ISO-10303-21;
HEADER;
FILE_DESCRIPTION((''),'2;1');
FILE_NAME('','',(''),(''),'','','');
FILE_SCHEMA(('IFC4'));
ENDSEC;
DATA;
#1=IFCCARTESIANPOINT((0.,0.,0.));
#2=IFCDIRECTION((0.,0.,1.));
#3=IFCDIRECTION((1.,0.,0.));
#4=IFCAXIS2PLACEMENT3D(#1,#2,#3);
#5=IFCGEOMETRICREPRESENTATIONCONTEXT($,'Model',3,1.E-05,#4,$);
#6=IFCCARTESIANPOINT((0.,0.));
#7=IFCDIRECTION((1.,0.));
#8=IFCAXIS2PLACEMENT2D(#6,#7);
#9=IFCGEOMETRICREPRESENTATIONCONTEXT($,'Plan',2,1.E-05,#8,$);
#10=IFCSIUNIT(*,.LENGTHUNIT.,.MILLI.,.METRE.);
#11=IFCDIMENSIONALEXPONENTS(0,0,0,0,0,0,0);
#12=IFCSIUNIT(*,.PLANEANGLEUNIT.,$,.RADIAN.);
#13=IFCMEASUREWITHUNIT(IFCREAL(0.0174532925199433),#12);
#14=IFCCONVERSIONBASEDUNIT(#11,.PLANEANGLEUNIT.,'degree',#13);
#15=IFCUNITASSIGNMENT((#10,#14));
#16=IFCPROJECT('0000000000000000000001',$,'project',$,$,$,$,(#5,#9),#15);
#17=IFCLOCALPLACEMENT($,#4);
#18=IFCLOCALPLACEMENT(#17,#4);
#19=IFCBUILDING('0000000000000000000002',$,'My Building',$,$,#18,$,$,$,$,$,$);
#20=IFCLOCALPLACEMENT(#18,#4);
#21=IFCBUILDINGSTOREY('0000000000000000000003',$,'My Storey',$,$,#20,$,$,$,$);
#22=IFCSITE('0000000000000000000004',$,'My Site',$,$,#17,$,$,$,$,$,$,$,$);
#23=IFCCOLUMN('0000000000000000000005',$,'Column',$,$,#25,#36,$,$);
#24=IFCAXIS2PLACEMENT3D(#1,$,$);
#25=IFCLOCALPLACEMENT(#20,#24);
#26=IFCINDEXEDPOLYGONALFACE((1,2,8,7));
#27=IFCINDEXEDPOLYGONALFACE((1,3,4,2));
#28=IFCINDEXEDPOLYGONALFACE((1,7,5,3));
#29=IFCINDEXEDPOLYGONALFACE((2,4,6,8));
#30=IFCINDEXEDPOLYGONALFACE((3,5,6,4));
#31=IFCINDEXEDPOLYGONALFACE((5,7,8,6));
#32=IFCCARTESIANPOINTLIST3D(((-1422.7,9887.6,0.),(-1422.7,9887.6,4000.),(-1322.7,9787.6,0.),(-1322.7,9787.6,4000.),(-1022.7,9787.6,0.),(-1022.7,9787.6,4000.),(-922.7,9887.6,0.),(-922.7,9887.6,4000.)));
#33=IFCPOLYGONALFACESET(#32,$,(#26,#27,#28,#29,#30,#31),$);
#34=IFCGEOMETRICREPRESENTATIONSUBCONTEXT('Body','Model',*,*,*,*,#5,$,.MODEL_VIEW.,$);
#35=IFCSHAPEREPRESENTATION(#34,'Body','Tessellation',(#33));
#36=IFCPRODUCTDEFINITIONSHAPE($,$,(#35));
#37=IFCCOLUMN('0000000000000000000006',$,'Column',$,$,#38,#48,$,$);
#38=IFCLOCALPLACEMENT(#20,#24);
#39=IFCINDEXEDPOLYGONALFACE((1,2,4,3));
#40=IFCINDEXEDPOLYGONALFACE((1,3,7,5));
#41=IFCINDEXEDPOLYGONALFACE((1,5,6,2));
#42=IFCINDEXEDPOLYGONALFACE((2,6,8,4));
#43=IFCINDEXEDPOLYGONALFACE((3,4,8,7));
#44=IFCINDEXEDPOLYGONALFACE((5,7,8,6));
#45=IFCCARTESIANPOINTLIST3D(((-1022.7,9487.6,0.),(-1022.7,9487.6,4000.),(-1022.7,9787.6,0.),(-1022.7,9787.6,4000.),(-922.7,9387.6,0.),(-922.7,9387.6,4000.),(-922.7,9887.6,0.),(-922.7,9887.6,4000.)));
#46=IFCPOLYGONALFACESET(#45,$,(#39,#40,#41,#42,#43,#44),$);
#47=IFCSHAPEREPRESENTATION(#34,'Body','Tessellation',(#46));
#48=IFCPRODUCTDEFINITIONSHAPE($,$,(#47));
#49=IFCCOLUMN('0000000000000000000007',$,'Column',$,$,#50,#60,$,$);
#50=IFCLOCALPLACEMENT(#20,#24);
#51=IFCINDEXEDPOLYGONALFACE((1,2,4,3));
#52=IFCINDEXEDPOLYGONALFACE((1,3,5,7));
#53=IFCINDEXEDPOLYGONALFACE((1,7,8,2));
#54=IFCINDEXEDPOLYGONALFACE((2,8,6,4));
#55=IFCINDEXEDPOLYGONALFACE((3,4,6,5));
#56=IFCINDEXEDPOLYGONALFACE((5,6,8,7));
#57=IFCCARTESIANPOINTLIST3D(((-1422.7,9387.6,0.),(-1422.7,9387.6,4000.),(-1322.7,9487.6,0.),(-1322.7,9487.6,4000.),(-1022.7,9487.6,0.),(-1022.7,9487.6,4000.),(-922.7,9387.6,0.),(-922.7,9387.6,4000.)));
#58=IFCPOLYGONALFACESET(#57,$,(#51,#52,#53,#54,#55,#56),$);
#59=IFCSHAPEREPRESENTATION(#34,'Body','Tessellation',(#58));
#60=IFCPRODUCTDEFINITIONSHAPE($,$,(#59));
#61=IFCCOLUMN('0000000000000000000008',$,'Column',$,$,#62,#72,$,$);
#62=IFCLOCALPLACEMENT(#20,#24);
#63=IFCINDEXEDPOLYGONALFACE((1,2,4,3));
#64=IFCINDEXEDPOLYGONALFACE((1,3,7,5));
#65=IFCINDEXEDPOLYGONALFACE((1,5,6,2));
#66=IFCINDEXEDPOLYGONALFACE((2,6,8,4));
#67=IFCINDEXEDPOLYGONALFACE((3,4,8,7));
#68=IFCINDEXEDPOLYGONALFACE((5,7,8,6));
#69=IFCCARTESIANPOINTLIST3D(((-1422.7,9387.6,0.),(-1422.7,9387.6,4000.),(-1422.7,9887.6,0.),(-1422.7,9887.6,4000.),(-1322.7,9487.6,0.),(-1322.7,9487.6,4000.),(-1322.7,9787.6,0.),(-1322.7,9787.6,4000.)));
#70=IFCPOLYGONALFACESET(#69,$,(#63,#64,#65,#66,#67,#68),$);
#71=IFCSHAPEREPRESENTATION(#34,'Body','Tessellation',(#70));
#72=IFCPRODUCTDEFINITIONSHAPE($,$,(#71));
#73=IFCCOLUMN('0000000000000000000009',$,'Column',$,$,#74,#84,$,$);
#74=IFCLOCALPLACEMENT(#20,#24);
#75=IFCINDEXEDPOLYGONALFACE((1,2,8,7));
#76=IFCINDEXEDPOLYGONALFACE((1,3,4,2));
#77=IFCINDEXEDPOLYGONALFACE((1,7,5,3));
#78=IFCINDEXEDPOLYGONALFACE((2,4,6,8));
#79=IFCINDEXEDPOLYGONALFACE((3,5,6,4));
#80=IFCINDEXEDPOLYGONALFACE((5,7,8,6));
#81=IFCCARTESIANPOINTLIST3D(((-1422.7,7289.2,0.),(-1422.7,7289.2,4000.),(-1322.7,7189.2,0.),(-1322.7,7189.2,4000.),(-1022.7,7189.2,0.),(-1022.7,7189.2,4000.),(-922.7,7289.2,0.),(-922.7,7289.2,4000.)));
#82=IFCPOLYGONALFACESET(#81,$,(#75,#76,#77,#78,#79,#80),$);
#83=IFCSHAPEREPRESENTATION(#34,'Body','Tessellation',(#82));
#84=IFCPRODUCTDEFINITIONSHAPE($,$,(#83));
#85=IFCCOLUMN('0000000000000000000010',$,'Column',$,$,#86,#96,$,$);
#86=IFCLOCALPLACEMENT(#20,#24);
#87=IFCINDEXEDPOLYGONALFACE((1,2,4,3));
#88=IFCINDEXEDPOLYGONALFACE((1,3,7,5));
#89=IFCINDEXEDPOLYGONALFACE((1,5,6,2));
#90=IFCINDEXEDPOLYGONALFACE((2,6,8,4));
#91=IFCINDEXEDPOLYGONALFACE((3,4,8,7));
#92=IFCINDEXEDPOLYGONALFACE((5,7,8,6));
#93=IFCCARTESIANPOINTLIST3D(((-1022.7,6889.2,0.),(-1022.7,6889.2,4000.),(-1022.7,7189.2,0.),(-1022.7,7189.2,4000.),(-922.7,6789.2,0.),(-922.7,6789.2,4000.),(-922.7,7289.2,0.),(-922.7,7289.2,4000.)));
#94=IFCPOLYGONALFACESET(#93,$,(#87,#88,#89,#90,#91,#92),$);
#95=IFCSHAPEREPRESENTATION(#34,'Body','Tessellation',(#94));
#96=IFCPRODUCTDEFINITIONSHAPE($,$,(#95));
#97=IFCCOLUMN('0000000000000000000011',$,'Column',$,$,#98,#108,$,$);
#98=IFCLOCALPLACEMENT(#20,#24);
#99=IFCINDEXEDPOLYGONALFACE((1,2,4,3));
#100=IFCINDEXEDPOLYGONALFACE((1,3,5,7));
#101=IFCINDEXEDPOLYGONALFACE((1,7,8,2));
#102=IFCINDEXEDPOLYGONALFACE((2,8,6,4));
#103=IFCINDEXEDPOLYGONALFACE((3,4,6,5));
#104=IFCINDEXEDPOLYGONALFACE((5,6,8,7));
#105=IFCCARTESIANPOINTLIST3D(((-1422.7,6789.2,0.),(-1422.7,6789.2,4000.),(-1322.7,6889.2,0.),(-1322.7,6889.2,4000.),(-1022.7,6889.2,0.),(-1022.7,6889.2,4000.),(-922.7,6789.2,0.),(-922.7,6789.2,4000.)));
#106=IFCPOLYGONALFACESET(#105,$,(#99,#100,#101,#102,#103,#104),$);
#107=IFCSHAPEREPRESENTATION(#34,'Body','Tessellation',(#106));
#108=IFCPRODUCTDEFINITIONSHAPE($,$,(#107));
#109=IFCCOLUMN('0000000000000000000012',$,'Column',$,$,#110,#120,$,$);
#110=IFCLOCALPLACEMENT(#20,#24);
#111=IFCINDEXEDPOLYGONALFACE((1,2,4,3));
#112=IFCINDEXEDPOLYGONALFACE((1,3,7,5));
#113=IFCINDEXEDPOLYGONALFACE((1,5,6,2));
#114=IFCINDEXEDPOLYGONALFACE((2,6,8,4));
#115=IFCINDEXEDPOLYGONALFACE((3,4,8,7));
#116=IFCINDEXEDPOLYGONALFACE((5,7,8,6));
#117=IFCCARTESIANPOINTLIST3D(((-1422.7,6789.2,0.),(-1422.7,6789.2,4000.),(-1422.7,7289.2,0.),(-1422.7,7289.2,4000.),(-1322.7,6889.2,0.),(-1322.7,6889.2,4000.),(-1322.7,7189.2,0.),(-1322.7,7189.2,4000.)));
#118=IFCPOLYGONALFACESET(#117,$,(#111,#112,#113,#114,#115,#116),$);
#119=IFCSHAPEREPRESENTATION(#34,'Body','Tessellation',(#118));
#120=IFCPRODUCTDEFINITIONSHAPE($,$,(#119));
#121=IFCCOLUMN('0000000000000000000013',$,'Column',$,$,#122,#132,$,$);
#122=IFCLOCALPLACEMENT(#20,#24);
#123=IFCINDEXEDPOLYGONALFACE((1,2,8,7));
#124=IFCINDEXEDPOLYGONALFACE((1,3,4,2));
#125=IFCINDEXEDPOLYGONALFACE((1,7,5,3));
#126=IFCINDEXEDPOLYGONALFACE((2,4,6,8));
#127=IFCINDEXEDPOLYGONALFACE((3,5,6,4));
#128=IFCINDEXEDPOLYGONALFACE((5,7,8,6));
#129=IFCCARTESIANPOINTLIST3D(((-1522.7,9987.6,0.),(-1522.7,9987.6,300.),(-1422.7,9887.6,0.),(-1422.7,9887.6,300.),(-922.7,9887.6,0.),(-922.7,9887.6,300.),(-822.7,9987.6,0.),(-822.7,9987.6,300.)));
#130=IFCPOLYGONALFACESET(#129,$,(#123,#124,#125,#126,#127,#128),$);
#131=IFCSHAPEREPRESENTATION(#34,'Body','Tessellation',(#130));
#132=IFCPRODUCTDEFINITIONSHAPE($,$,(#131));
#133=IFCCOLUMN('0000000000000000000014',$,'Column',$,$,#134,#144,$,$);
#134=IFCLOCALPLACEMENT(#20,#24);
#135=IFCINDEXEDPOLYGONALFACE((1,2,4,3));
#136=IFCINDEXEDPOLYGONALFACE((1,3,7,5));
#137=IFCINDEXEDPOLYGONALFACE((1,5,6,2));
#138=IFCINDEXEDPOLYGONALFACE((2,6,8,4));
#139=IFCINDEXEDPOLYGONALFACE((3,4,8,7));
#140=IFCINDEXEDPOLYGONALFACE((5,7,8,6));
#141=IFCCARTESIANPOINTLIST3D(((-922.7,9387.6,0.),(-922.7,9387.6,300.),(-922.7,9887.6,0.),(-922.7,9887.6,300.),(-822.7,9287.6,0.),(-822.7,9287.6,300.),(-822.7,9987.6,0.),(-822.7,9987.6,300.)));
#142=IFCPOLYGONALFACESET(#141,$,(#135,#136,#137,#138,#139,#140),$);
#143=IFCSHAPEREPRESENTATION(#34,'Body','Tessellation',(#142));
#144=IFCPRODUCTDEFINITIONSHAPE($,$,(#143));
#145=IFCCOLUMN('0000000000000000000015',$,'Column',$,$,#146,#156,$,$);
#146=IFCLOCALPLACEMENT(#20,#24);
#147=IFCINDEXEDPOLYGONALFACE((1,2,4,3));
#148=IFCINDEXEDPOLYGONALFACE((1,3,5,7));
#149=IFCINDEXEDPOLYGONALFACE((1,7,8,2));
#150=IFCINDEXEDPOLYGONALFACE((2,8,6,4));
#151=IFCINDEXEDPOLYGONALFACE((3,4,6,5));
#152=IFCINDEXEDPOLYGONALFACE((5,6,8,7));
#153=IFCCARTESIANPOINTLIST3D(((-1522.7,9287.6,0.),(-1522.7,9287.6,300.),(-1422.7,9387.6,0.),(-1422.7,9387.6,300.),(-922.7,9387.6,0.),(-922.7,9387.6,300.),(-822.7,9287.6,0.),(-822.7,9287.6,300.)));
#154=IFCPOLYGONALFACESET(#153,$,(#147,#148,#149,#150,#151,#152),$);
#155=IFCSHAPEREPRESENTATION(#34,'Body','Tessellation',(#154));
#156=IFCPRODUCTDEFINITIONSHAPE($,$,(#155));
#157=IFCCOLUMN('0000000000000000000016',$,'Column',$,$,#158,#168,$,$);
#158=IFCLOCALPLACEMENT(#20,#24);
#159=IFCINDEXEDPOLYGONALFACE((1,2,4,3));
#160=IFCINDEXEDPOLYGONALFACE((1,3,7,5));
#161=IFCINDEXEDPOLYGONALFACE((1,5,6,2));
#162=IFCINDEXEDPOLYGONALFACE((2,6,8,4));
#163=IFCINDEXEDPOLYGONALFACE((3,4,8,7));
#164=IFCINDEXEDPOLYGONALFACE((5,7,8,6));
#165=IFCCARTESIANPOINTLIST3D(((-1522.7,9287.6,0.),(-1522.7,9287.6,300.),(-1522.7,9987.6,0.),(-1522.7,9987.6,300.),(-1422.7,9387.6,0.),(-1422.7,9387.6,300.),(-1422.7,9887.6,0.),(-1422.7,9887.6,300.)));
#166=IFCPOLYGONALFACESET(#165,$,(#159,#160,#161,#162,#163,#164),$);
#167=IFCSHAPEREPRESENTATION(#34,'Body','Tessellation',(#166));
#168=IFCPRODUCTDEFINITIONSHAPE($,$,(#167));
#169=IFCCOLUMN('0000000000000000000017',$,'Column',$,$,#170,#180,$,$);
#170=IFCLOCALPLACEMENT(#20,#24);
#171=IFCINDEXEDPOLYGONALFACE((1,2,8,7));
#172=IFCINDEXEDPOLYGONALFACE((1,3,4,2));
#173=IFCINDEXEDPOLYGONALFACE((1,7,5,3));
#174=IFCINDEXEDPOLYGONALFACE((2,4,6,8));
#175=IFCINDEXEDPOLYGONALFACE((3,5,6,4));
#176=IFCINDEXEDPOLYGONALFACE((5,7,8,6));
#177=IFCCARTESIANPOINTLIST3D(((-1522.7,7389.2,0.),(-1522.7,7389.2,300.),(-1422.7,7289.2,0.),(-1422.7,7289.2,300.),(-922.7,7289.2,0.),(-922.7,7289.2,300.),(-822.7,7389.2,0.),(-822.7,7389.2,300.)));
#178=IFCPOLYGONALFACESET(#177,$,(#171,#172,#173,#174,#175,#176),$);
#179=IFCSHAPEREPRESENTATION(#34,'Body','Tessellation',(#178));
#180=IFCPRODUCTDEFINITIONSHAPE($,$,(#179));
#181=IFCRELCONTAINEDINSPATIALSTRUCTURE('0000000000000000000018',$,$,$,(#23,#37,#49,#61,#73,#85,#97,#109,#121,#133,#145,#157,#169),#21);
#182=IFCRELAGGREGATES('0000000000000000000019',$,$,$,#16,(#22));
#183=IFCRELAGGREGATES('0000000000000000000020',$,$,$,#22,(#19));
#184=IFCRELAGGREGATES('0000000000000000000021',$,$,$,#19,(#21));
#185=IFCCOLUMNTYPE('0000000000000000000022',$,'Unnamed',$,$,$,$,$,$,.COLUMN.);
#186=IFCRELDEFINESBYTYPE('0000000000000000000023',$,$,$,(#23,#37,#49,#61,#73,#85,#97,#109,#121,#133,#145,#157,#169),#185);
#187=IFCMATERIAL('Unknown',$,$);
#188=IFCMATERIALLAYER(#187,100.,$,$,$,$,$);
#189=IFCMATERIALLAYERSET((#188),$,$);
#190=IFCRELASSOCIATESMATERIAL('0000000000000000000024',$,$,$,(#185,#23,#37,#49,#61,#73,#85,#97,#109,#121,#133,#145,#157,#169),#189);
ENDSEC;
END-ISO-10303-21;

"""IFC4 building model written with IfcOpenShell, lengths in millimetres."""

from ifc_helpers import new_model, entity, si_unit, converted_unit, frame, origin_with_axes, origin_2d_with_axis, place, context, subcontext, project, spatial, line, indexed_curve, outline, extrude, material, layer, layer_set, layer_usage, type_object, element, save


model = new_model("IFC4")

# Units and contexts
model_context = context("Model", 3, precision=1e-05, world=origin_with_axes())
plan_context = context("Plan", 2, precision=1e-05, world=origin_2d_with_axis())
body_context = subcontext(model_context, "Body", "Model", "MODEL_VIEW")
ifc_project = project(units=[si_unit("LENGTHUNIT", "METRE", prefix="MILLI"), converted_unit("PLANEANGLEUNIT", "degree", entity("IfcReal", 0.0174532925199433), si_unit("PLANEANGLEUNIT", "RADIAN"), dimensions=[0, 0, 0, 0, 0, 0, 0])], contexts=[model_context, plan_context])

# Site, building, storey
site_placement = place(None, origin_with_axes())
site = spatial("IfcSite", under=ifc_project, at=site_placement, Name="My Site")
building_placement = place(site_placement, origin_with_axes())
building = spatial("IfcBuilding", under=site, at=building_placement, Name="My Building")
storey_placement = place(building_placement, origin_with_axes())
storey = spatial("IfcBuildingStorey", under=building, at=storey_placement, Name="My Storey")

# Columns
ifc_material = material(Name="Unknown")
ifc_layer_1 = layer(ifc_material, 100.0)
ifc_layer_set_1 = layer_set([ifc_layer_1])
ifc_layer_usage_1 = layer_usage(ifc_layer_set_1, "AXIS2", "POSITIVE", 0.0)
column_type = type_object("IfcColumnType", Name="Unnamed", PredefinedType="COLUMN", material=ifc_layer_set_1)
column_1_placement = place(storey_placement, frame((-1322.7, 9787.6, 0.0), z_axis=(0.0, 0.0, 1.0), x_axis=(1.0, 0.0, 0.0)))
element("IfcColumn", 1, at=column_1_placement, inside=storey, type_object=column_type, material=ifc_layer_usage_1, Name="Column", context=body_context, shape_type="SweptSolid", body=[
    extrude(outline(indexed_curve([(0.0, 0.0), (-100.0, 100.0), (400.0, 100.0), (300.0, 0.0)], segments=[line(1, 2, 3, 4, 1)])), origin_with_axes(), (0.0, 0.0, 1.0), 4000.0),
])
ifc_layer_usage_2 = layer_usage(ifc_layer_set_1, "AXIS2", "POSITIVE", 0.0)
column_2_placement = place(storey_placement, frame((-1022.7, 9787.6, 0.0), z_axis=(0.0, 0.0, 1.0), x_axis=(0.0, -1.0, 0.0)))
element("IfcColumn", 2, at=column_2_placement, inside=storey, type_object=column_type, material=ifc_layer_usage_2, Name="Column", context=body_context, shape_type="SweptSolid", body=[
    extrude(outline(indexed_curve([(0.0, 0.0), (-100.0, 100.0), (400.0, 100.0), (300.0, 0.0)], segments=[line(1, 2, 3, 4, 1)])), origin_with_axes(), (0.0, 0.0, 1.0), 4000.0),
])
ifc_layer_usage_3 = layer_usage(ifc_layer_set_1, "AXIS2", "POSITIVE", 0.0)
column_3_placement = place(storey_placement, frame((-1022.7, 9487.6, 0.0), z_axis=(0.0, 0.0, 1.0), x_axis=(-1.0, 0.0, 0.0)))
element("IfcColumn", 3, at=column_3_placement, inside=storey, type_object=column_type, material=ifc_layer_usage_3, Name="Column", context=body_context, shape_type="SweptSolid", body=[
    extrude(outline(indexed_curve([(0.0, 0.0), (-100.0, 100.0), (400.0, 100.0), (300.0, 0.0)], segments=[line(1, 2, 3, 4, 1)])), origin_with_axes(), (0.0, 0.0, 1.0), 4000.0),
])
ifc_layer_usage_4 = layer_usage(ifc_layer_set_1, "AXIS2", "POSITIVE", 0.0)
column_4_placement = place(storey_placement, frame((-1322.7, 9487.6, 0.0), z_axis=(0.0, 0.0, 1.0), x_axis=(0.0, 1.0, 0.0)))
element("IfcColumn", 4, at=column_4_placement, inside=storey, type_object=column_type, material=ifc_layer_usage_4, Name="Column", context=body_context, shape_type="SweptSolid", body=[
    extrude(outline(indexed_curve([(0.0, 0.0), (-100.0, 100.0), (400.0, 100.0), (300.0, 0.0)], segments=[line(1, 2, 3, 4, 1)])), origin_with_axes(), (0.0, 0.0, 1.0), 4000.0),
])
ifc_layer_usage_5 = layer_usage(ifc_layer_set_1, "AXIS2", "POSITIVE", 0.0)
column_5_placement = place(storey_placement, frame((-1322.7, 7189.2, 0.0), z_axis=(0.0, 0.0, 1.0), x_axis=(1.0, 0.0, 0.0)))
element("IfcColumn", 5, at=column_5_placement, inside=storey, type_object=column_type, material=ifc_layer_usage_5, Name="Column", context=body_context, shape_type="SweptSolid", body=[
    extrude(outline(indexed_curve([(0.0, 0.0), (-100.0, 100.0), (400.0, 100.0), (300.0, 0.0)], segments=[line(1, 2, 3, 4, 1)])), origin_with_axes(), (0.0, 0.0, 1.0), 4000.0),
])
ifc_layer_usage_6 = layer_usage(ifc_layer_set_1, "AXIS2", "POSITIVE", 0.0)
column_6_placement = place(storey_placement, frame((-1022.7, 7189.2, 0.0), z_axis=(0.0, 0.0, 1.0), x_axis=(0.0, -1.0, 0.0)))
element("IfcColumn", 6, at=column_6_placement, inside=storey, type_object=column_type, material=ifc_layer_usage_6, Name="Column", context=body_context, shape_type="SweptSolid", body=[
    extrude(outline(indexed_curve([(0.0, 0.0), (-100.0, 100.0), (400.0, 100.0), (300.0, 0.0)], segments=[line(1, 2, 3, 4, 1)])), origin_with_axes(), (0.0, 0.0, 1.0), 4000.0),
])
ifc_layer_usage_7 = layer_usage(ifc_layer_set_1, "AXIS2", "POSITIVE", 0.0)
column_7_placement = place(storey_placement, frame((-1022.7, 6889.2, 0.0), z_axis=(0.0, 0.0, 1.0), x_axis=(-1.0, 0.0, 0.0)))
element("IfcColumn", 7, at=column_7_placement, inside=storey, type_object=column_type, material=ifc_layer_usage_7, Name="Column", context=body_context, shape_type="SweptSolid", body=[
    extrude(outline(indexed_curve([(0.0, 0.0), (-100.0, 100.0), (400.0, 100.0), (300.0, 0.0)], segments=[line(1, 2, 3, 4, 1)])), origin_with_axes(), (0.0, 0.0, 1.0), 4000.0),
])
ifc_layer_usage_8 = layer_usage(ifc_layer_set_1, "AXIS2", "POSITIVE", 0.0)
column_8_placement = place(storey_placement, frame((-1322.7, 6889.2, 0.0), z_axis=(0.0, 0.0, 1.0), x_axis=(0.0, 1.0, 0.0)))
element("IfcColumn", 8, at=column_8_placement, inside=storey, type_object=column_type, material=ifc_layer_usage_8, Name="Column", context=body_context, shape_type="SweptSolid", body=[
    extrude(outline(indexed_curve([(0.0, 0.0), (-100.0, 100.0), (400.0, 100.0), (300.0, 0.0)], segments=[line(1, 2, 3, 4, 1)])), origin_with_axes(), (0.0, 0.0, 1.0), 4000.0),
])
ifc_layer_usage_9 = layer_usage(ifc_layer_set_1, "AXIS2", "POSITIVE", 0.0)
column_9_placement = place(storey_placement, frame((-1422.7, 9887.6, 0.0), z_axis=(0.0, 0.0, 1.0), x_axis=(1.0, 0.0, 0.0)))
element("IfcColumn", 9, at=column_9_placement, inside=storey, type_object=column_type, material=ifc_layer_usage_9, Name="Column", context=body_context, shape_type="SweptSolid", body=[
    extrude(outline(indexed_curve([(0.0, 0.0), (-100.0, 100.0), (600.0, 100.0), (500.0, 0.0)], segments=[line(1, 2, 3, 4, 1)])), origin_with_axes(), (0.0, 0.0, 1.0), 300.0),
])
ifc_layer_usage_10 = layer_usage(ifc_layer_set_1, "AXIS2", "POSITIVE", 0.0)
column_10_placement = place(storey_placement, frame((-922.7, 9887.6, 0.0), z_axis=(0.0, 0.0, 1.0), x_axis=(0.0, -1.0, 0.0)))
element("IfcColumn", 10, at=column_10_placement, inside=storey, type_object=column_type, material=ifc_layer_usage_10, Name="Column", context=body_context, shape_type="SweptSolid", body=[
    extrude(outline(indexed_curve([(0.0, 0.0), (-100.0, 100.0), (600.0, 100.0), (500.0, 0.0)], segments=[line(1, 2, 3, 4, 1)])), origin_with_axes(), (0.0, 0.0, 1.0), 300.0),
])
ifc_layer_usage_11 = layer_usage(ifc_layer_set_1, "AXIS2", "POSITIVE", 0.0)
column_11_placement = place(storey_placement, frame((-922.7, 9387.6, 0.0), z_axis=(0.0, 0.0, 1.0), x_axis=(-1.0, 0.0, 0.0)))
element("IfcColumn", 11, at=column_11_placement, inside=storey, type_object=column_type, material=ifc_layer_usage_11, Name="Column", context=body_context, shape_type="SweptSolid", body=[
    extrude(outline(indexed_curve([(0.0, 0.0), (-100.0, 100.0), (600.0, 100.0), (500.0, 0.0)], segments=[line(1, 2, 3, 4, 1)])), origin_with_axes(), (0.0, 0.0, 1.0), 300.0),
])
ifc_layer_usage_12 = layer_usage(ifc_layer_set_1, "AXIS2", "POSITIVE", 0.0)
column_12_placement = place(storey_placement, frame((-1422.7, 9387.6, 0.0), z_axis=(0.0, 0.0, 1.0), x_axis=(0.0, 1.0, 0.0)))
element("IfcColumn", 12, at=column_12_placement, inside=storey, type_object=column_type, material=ifc_layer_usage_12, Name="Column", context=body_context, shape_type="SweptSolid", body=[
    extrude(outline(indexed_curve([(0.0, 0.0), (-100.0, 100.0), (600.0, 100.0), (500.0, 0.0)], segments=[line(1, 2, 3, 4, 1)])), origin_with_axes(), (0.0, 0.0, 1.0), 300.0),
])
ifc_layer_usage_13 = layer_usage(ifc_layer_set_1, "AXIS2", "POSITIVE", 0.0)
column_13_placement = place(storey_placement, frame((-1422.7, 7289.2, 0.0), z_axis=(0.0, 0.0, 1.0), x_axis=(1.0, 0.0, 0.0)))
element("IfcColumn", 13, at=column_13_placement, inside=storey, type_object=column_type, material=ifc_layer_usage_13, Name="Column", context=body_context, shape_type="SweptSolid", body=[
    extrude(outline(indexed_curve([(0.0, 0.0), (-100.0, 100.0), (600.0, 100.0), (500.0, 0.0)], segments=[line(1, 2, 3, 4, 1)])), origin_with_axes(), (0.0, 0.0, 1.0), 300.0),
])

save(model, "model.ifc")
